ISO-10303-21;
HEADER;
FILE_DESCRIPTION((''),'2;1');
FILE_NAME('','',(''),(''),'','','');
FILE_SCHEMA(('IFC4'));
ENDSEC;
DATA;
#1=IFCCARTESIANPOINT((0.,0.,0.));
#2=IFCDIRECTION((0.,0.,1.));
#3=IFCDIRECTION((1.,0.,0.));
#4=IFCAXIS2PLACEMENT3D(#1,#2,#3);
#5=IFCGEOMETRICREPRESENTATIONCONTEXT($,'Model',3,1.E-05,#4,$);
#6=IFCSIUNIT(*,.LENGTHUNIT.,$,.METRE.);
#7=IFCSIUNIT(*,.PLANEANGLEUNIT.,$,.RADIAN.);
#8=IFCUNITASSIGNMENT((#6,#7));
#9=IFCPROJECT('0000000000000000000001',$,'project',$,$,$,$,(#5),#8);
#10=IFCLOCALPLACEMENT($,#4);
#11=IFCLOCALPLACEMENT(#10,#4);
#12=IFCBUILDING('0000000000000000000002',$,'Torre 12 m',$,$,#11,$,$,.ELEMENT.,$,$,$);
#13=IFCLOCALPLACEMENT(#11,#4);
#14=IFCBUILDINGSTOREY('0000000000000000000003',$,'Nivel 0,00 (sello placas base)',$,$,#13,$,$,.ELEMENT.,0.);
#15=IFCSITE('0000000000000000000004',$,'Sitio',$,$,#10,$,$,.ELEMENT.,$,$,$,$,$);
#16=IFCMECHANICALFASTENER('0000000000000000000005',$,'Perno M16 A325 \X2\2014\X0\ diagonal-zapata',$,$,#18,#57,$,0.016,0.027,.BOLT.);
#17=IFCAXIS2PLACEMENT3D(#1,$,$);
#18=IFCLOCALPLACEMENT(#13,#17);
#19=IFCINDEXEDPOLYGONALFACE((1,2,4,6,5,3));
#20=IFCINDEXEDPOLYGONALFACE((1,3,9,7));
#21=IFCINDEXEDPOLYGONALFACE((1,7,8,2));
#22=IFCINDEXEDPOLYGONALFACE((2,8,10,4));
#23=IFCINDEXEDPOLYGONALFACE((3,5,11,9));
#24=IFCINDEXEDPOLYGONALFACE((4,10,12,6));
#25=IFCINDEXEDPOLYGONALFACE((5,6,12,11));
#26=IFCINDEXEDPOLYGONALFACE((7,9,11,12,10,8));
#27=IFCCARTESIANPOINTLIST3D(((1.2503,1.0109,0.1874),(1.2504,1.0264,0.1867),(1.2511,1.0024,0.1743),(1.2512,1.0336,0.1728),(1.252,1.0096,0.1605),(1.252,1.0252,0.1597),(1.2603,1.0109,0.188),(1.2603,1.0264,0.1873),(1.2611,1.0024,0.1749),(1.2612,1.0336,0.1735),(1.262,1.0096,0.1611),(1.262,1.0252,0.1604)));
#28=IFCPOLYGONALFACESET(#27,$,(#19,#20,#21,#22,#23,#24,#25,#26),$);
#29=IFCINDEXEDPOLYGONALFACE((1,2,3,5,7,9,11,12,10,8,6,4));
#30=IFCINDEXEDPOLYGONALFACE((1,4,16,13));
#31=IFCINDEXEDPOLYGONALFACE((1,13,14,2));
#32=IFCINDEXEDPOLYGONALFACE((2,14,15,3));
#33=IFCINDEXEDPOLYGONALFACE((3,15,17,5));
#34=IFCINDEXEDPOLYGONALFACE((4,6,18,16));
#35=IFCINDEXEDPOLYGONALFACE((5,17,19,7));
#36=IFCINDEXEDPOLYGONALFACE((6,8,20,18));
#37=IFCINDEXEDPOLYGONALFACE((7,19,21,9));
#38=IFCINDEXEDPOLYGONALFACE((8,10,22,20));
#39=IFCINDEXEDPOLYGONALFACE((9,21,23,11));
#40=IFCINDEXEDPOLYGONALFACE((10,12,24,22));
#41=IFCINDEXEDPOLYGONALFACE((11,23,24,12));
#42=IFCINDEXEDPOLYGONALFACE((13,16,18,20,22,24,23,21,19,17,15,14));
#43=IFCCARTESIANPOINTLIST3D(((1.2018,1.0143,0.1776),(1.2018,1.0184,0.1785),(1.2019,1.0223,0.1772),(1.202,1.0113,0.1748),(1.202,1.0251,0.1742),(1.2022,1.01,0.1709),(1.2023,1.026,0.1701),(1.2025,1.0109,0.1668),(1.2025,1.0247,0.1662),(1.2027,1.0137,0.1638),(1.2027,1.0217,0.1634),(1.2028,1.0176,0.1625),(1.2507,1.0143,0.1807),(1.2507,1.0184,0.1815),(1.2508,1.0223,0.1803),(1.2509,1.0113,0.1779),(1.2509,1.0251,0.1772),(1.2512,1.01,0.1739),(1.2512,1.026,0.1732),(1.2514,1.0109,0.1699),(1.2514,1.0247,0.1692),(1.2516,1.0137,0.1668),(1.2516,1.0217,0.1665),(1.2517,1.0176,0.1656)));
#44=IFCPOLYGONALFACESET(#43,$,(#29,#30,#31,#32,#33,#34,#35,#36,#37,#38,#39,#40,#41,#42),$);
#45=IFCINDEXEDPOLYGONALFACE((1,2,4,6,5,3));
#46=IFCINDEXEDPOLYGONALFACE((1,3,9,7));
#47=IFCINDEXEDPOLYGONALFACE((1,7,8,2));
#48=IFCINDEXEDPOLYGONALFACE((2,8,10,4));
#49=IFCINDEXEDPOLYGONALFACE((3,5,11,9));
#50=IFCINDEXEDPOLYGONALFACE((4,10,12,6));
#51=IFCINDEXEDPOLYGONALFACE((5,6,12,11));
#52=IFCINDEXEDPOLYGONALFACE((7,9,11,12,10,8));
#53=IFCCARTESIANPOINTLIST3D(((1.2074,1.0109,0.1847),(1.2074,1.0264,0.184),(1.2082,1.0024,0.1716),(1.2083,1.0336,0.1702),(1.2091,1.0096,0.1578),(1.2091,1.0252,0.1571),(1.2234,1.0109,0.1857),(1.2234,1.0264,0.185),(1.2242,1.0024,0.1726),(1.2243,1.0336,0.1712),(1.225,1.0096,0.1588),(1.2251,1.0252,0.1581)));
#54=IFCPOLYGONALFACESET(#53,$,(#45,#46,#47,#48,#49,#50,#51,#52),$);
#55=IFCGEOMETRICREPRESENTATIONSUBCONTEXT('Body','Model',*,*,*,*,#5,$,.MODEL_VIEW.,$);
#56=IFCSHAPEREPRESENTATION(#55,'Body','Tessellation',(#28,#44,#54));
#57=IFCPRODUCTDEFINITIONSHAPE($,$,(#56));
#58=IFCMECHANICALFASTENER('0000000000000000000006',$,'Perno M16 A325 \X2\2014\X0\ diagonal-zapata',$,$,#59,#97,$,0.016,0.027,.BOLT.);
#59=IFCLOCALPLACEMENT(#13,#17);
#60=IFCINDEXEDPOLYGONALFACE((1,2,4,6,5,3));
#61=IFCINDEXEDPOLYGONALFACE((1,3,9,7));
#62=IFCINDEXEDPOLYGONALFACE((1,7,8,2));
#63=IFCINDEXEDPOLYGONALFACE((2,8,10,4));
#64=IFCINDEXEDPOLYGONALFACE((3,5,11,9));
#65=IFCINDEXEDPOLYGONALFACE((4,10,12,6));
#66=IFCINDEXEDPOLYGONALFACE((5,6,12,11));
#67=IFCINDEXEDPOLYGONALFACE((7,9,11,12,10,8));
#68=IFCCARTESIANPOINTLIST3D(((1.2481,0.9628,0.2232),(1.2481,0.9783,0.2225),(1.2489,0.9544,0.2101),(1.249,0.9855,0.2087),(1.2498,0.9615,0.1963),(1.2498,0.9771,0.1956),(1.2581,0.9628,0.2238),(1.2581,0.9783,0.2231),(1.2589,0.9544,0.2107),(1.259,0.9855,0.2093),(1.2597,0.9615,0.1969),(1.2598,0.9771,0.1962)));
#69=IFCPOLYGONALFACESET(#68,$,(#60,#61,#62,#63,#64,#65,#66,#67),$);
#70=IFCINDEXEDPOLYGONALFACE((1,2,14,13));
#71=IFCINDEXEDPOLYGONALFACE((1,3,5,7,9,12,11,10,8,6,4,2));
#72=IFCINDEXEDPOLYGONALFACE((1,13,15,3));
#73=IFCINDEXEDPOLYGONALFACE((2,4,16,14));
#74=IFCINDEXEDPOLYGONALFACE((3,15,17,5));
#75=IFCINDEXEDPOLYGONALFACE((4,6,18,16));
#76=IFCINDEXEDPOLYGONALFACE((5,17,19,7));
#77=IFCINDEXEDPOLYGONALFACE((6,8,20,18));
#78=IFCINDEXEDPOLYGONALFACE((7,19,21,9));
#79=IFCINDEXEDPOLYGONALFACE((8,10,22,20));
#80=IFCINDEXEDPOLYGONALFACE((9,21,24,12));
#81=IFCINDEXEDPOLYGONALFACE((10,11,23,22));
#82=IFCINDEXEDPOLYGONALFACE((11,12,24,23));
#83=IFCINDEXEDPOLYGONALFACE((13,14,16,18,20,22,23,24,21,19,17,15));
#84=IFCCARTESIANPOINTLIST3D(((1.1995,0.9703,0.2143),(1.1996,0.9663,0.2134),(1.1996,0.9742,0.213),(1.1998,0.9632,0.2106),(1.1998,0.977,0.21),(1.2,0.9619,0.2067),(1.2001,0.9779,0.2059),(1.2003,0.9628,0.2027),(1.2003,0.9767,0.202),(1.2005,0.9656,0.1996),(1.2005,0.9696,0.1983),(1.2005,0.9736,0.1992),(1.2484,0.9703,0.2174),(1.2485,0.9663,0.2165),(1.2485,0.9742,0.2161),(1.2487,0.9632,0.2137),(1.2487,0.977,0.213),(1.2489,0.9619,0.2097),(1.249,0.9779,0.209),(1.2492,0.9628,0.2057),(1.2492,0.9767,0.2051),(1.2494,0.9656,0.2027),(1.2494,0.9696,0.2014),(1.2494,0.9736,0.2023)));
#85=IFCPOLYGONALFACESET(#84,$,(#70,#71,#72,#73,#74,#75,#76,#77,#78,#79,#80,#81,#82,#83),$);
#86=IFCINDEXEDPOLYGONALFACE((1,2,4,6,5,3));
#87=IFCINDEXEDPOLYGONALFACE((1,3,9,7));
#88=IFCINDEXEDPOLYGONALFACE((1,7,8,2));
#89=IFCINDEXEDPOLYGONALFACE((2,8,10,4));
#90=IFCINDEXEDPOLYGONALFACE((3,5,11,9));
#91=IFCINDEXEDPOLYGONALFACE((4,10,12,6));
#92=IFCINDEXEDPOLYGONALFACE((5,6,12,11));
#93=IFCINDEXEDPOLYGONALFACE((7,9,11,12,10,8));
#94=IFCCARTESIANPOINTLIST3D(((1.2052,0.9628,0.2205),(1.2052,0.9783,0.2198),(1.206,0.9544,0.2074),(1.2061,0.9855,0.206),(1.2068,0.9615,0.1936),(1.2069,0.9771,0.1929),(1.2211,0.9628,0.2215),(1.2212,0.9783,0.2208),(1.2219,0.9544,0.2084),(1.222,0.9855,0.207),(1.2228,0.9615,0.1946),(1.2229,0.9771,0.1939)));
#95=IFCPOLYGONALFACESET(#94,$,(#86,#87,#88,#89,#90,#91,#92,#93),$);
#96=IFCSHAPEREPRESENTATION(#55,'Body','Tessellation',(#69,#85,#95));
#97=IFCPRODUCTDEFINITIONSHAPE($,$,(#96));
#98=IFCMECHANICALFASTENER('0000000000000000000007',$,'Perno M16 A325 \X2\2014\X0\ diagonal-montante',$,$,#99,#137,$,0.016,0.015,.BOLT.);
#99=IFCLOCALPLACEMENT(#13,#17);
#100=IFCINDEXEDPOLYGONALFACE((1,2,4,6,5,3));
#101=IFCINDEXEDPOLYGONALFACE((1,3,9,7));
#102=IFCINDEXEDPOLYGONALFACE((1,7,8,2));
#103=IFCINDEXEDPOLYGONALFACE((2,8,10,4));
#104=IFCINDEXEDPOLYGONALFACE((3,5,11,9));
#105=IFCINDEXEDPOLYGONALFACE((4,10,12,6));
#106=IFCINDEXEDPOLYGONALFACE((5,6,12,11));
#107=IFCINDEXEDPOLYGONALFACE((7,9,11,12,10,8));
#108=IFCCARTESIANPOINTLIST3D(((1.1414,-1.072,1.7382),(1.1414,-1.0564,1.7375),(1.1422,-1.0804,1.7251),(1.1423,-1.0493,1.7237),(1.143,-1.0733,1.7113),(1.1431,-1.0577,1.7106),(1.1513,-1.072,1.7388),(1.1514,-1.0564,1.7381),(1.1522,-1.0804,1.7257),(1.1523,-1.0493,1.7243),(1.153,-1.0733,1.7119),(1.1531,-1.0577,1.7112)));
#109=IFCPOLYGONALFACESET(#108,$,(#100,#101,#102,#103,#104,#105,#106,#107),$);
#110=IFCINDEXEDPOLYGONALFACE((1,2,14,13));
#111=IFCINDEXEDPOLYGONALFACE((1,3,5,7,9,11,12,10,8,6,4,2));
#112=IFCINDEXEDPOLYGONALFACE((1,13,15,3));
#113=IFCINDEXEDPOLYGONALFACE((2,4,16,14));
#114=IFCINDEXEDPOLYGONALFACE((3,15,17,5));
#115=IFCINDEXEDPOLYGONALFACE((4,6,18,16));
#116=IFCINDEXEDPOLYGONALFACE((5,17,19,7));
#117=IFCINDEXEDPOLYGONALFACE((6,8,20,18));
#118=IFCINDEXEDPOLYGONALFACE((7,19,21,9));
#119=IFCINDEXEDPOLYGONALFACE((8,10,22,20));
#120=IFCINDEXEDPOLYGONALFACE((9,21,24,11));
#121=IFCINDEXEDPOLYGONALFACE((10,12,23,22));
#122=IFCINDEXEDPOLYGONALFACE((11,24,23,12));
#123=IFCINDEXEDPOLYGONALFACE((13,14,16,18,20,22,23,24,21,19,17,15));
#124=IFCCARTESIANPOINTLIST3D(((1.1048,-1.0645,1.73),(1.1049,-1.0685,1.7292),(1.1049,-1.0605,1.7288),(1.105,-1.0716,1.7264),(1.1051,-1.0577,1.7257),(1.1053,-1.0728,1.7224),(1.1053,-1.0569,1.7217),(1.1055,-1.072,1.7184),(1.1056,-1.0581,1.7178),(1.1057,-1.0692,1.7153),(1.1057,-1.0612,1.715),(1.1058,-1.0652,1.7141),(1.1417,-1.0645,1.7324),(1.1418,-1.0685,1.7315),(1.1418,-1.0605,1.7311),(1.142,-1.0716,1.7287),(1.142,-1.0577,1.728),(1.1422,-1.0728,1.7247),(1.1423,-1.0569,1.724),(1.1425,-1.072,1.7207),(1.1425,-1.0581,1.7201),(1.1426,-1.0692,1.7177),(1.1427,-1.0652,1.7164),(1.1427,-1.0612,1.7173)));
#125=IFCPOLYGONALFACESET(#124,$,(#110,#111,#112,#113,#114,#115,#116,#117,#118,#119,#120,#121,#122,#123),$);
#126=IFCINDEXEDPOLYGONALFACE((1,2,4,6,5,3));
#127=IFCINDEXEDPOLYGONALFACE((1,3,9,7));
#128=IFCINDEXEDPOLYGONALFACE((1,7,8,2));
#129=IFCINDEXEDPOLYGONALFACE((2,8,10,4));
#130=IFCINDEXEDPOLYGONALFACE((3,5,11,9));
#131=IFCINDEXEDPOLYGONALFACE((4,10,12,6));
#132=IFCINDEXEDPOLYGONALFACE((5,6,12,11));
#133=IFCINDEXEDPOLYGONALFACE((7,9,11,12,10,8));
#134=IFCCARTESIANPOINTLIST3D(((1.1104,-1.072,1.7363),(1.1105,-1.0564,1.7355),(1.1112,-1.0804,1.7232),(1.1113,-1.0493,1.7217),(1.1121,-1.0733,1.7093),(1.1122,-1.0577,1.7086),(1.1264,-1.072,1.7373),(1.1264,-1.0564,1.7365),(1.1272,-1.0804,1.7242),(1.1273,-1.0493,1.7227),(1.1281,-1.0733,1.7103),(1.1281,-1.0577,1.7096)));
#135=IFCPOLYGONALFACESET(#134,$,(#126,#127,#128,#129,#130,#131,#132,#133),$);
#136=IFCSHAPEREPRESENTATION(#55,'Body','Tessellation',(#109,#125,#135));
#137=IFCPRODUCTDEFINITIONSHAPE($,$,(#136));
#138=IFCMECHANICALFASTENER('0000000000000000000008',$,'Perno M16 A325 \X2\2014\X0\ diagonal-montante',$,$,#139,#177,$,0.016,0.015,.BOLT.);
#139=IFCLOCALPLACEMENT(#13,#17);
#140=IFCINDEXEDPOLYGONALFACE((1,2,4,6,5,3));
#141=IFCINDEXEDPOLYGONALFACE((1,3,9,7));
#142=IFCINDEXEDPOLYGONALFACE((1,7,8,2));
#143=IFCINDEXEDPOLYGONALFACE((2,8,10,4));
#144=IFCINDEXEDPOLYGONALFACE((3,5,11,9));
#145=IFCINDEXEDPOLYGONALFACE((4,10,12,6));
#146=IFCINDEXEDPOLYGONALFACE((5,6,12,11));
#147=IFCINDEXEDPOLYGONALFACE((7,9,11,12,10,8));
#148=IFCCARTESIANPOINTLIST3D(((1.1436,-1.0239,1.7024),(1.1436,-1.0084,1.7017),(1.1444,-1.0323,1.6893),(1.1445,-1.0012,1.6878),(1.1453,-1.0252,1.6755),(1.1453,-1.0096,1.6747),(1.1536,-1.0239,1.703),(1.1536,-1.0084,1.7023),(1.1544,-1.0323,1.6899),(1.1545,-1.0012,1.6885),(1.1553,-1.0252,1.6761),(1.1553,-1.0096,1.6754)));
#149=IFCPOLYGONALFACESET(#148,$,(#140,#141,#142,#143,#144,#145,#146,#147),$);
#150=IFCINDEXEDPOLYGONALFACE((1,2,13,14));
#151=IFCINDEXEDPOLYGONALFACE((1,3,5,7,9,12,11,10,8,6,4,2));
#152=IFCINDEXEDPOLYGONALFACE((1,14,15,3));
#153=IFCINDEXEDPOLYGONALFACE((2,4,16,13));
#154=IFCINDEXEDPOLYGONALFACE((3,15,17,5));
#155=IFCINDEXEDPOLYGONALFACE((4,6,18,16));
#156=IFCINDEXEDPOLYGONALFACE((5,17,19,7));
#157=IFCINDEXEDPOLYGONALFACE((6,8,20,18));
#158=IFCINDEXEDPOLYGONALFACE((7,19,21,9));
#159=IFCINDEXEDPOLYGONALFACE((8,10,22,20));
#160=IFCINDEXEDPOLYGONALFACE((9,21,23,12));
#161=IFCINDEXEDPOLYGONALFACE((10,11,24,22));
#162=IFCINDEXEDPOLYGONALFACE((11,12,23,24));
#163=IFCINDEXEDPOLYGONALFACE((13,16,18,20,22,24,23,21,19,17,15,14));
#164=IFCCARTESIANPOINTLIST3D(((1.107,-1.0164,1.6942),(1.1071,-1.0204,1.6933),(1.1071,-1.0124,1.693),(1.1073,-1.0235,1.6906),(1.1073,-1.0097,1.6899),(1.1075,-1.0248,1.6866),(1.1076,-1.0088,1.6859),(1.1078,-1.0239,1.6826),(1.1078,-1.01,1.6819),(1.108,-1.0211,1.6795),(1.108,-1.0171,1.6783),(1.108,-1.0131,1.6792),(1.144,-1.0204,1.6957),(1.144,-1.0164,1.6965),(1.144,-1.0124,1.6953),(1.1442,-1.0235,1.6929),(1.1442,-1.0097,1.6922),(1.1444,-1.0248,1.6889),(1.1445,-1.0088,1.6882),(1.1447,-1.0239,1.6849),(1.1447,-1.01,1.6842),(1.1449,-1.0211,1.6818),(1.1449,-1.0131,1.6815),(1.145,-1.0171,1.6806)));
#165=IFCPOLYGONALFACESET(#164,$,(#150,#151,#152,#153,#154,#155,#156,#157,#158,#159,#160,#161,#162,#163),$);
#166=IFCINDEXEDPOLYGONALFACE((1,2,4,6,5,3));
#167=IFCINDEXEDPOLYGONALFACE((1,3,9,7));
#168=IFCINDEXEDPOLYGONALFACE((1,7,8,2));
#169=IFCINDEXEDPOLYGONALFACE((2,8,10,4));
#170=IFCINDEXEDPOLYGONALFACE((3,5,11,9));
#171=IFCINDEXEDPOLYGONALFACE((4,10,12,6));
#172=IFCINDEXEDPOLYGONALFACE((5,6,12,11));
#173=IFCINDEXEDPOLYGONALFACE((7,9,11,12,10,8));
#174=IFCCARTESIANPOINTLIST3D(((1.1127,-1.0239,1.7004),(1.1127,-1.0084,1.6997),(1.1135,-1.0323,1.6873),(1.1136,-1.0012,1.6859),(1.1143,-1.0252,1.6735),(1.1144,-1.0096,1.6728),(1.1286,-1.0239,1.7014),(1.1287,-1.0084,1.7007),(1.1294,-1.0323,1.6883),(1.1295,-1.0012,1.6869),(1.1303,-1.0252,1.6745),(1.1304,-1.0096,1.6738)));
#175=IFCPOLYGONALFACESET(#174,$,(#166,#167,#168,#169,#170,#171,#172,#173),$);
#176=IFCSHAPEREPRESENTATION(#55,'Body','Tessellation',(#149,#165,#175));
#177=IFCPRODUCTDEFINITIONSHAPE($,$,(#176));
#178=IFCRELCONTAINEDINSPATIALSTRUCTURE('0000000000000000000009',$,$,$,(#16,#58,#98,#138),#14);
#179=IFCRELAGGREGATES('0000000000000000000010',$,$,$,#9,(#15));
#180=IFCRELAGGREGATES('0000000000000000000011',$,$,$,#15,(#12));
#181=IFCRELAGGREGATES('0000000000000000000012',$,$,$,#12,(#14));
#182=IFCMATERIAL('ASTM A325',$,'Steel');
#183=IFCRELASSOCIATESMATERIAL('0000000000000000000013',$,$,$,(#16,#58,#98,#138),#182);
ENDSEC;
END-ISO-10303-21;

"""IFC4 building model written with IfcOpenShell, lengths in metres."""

from ifc_helpers import new_model, si_unit, frame, origin_with_axes, place, context, subcontext, project, spatial, polyline, outline, extrude, material, element, save


model = new_model("IFC4")

# Units and contexts
model_context = context("Model", 3, precision=1e-05, world=origin_with_axes())
body_context = subcontext(model_context, "Body", "Model", "MODEL_VIEW")
ifc_project = project(units=[si_unit("LENGTHUNIT", "METRE"), si_unit("PLANEANGLEUNIT", "RADIAN")], contexts=[model_context])

# Site, building, storey
site_placement = place(None, origin_with_axes())
site = spatial("IfcSite", under=ifc_project, at=site_placement, Name="Sitio", CompositionType="ELEMENT")
building_placement = place(site_placement, origin_with_axes())
building = spatial("IfcBuilding", under=site, at=building_placement, Name="Torre 12 m", CompositionType="ELEMENT")
storey_placement = place(building_placement, origin_with_axes())
storey = spatial("IfcBuildingStorey", under=building, at=storey_placement, Name="Nivel 0,00 (sello placas base)", CompositionType="ELEMENT", Elevation=0.0)

# Shared definitions
placement = place(storey_placement, origin_with_axes())

# Mechanical fasteners
ifc_material_1 = material(Name="ASTM A325", Category="Steel")
element("IfcMechanicalFastener", 1, at=placement, inside=storey, material=ifc_material_1, Name="Perno M16 A325 — diagonal-zapata", NominalDiameter=0.016, NominalLength=0.027, PredefinedType="BOLT", context=body_context, shape_type="SweptSolid", body=[
    extrude(outline(polyline([(0.0135, 0.0078), (0.0, 0.0156), (-0.0135, 0.0078), (-0.0135, -0.0078), (0.0, -0.0156), (0.0135, -0.0078), (0.0135, 0.0078)])), frame((1.2612, 1.018, 0.1742), z_axis=(-0.998053, 0.0, -0.062378), x_axis=(0.033672, 0.841794, -0.538748)), (0.0, 0.0, 1.0), 0.01),
    extrude(outline(polyline([(0.008, 0.0), (0.0069, 0.004), (0.004, 0.0069), (0.0, 0.008), (-0.004, 0.0069), (-0.0069, 0.004), (-0.008, 0.0), (-0.0069, -0.004), (-0.004, -0.0069), (0.0, -0.008), (0.004, -0.0069), (0.0069, -0.004), (0.008, 0.0)])), frame((1.2512, 1.018, 0.1736), z_axis=(-0.998053, 0.0, -0.062378), x_axis=(0.033672, 0.841794, -0.538748)), (0.0, 0.0, 1.0), 0.049),
    extrude(outline(polyline([(0.0135, 0.0078), (0.0, 0.0156), (-0.0135, 0.0078), (-0.0135, -0.0078), (0.0, -0.0156), (0.0135, -0.0078), (0.0135, 0.0078)])), frame((1.2242, 1.018, 0.1719), z_axis=(-0.998053, 0.0, -0.062378), x_axis=(0.033672, 0.841794, -0.538748)), (0.0, 0.0, 1.0), 0.016),
])
element("IfcMechanicalFastener", 2, at=placement, inside=storey, material=ifc_material_1, Name="Perno M16 A325 — diagonal-zapata", NominalDiameter=0.016, NominalLength=0.027, PredefinedType="BOLT", context=body_context, shape_type="SweptSolid", body=[
    extrude(outline(polyline([(0.0135, 0.0078), (0.0, 0.0156), (-0.0135, 0.0078), (-0.0135, -0.0078), (0.0, -0.0156), (0.0135, -0.0078), (0.0135, 0.0078)])), frame((1.2589, 0.9699, 0.21), z_axis=(-0.998053, 0.0, -0.062378), x_axis=(0.033672, 0.841794, -0.538748)), (0.0, 0.0, 1.0), 0.01),
    extrude(outline(polyline([(0.008, 0.0), (0.0069, 0.004), (0.004, 0.0069), (0.0, 0.008), (-0.004, 0.0069), (-0.0069, 0.004), (-0.008, 0.0), (-0.0069, -0.004), (-0.004, -0.0069), (0.0, -0.008), (0.004, -0.0069), (0.0069, -0.004), (0.008, 0.0)])), frame((1.2489, 0.9699, 0.2094), z_axis=(-0.998053, 0.0, -0.062378), x_axis=(0.033672, 0.841794, -0.538748)), (0.0, 0.0, 1.0), 0.049),
    extrude(outline(polyline([(0.0135, 0.0078), (0.0, 0.0156), (-0.0135, 0.0078), (-0.0135, -0.0078), (0.0, -0.0156), (0.0135, -0.0078), (0.0135, 0.0078)])), frame((1.222, 0.9699, 0.2077), z_axis=(-0.998053, 0.0, -0.062378), x_axis=(0.033672, 0.841794, -0.538748)), (0.0, 0.0, 1.0), 0.016),
])
element("IfcMechanicalFastener", 3, at=placement, inside=storey, material=ifc_material_1, Name="Perno M16 A325 — diagonal-montante", NominalDiameter=0.016, NominalLength=0.015, PredefinedType="BOLT", context=body_context, shape_type="SweptSolid", body=[
    extrude(outline(polyline([(0.0135, 0.0078), (0.0, 0.0156), (-0.0135, 0.0078), (-0.0135, -0.0078), (0.0, -0.0156), (0.0135, -0.0078), (0.0135, 0.0078)])), frame((1.1522, -1.0649, 1.725), z_axis=(-0.998053, 0.0, -0.062378), x_axis=(0.033672, 0.841794, -0.538748)), (0.0, 0.0, 1.0), 0.01),
    extrude(outline(polyline([(0.008, 0.0), (0.0069, 0.004), (0.004, 0.0069), (0.0, 0.008), (-0.004, 0.0069), (-0.0069, 0.004), (-0.008, 0.0), (-0.0069, -0.004), (-0.004, -0.0069), (0.0, -0.008), (0.004, -0.0069), (0.0069, -0.004), (0.008, 0.0)])), frame((1.1422, -1.0649, 1.7244), z_axis=(-0.998053, 0.0, -0.062378), x_axis=(0.033672, 0.841794, -0.538748)), (0.0, 0.0, 1.0), 0.037),
    extrude(outline(polyline([(0.0135, 0.0078), (0.0, 0.0156), (-0.0135, 0.0078), (-0.0135, -0.0078), (0.0, -0.0156), (0.0135, -0.0078), (0.0135, 0.0078)])), frame((1.1273, -1.0649, 1.7234), z_axis=(-0.998053, 0.0, -0.062378), x_axis=(0.033672, 0.841794, -0.538748)), (0.0, 0.0, 1.0), 0.016),
])
element("IfcMechanicalFastener", 4, at=placement, inside=storey, material=ifc_material_1, Name="Perno M16 A325 — diagonal-montante", NominalDiameter=0.016, NominalLength=0.015, PredefinedType="BOLT", context=body_context, shape_type="SweptSolid", body=[
    extrude(outline(polyline([(0.0135, 0.0078), (0.0, 0.0156), (-0.0135, 0.0078), (-0.0135, -0.0078), (0.0, -0.0156), (0.0135, -0.0078), (0.0135, 0.0078)])), frame((1.1544, -1.0168, 1.6892), z_axis=(-0.998053, 0.0, -0.062378), x_axis=(0.033672, 0.841794, -0.538748)), (0.0, 0.0, 1.0), 0.01),
    extrude(outline(polyline([(0.008, 0.0), (0.0069, 0.004), (0.004, 0.0069), (0.0, 0.008), (-0.004, 0.0069), (-0.0069, 0.004), (-0.008, 0.0), (-0.0069, -0.004), (-0.004, -0.0069), (0.0, -0.008), (0.004, -0.0069), (0.0069, -0.004), (0.008, 0.0)])), frame((1.1445, -1.0168, 1.6886), z_axis=(-0.998053, 0.0, -0.062378), x_axis=(0.033672, 0.841794, -0.538748)), (0.0, 0.0, 1.0), 0.037),
    extrude(outline(polyline([(0.0135, 0.0078), (0.0, 0.0156), (-0.0135, 0.0078), (-0.0135, -0.0078), (0.0, -0.0156), (0.0135, -0.0078), (0.0135, 0.0078)])), frame((1.1295, -1.0168, 1.6876), z_axis=(-0.998053, 0.0, -0.062378), x_axis=(0.033672, 0.841794, -0.538748)), (0.0, 0.0, 1.0), 0.016),
])

save(model, "model.ifc")
